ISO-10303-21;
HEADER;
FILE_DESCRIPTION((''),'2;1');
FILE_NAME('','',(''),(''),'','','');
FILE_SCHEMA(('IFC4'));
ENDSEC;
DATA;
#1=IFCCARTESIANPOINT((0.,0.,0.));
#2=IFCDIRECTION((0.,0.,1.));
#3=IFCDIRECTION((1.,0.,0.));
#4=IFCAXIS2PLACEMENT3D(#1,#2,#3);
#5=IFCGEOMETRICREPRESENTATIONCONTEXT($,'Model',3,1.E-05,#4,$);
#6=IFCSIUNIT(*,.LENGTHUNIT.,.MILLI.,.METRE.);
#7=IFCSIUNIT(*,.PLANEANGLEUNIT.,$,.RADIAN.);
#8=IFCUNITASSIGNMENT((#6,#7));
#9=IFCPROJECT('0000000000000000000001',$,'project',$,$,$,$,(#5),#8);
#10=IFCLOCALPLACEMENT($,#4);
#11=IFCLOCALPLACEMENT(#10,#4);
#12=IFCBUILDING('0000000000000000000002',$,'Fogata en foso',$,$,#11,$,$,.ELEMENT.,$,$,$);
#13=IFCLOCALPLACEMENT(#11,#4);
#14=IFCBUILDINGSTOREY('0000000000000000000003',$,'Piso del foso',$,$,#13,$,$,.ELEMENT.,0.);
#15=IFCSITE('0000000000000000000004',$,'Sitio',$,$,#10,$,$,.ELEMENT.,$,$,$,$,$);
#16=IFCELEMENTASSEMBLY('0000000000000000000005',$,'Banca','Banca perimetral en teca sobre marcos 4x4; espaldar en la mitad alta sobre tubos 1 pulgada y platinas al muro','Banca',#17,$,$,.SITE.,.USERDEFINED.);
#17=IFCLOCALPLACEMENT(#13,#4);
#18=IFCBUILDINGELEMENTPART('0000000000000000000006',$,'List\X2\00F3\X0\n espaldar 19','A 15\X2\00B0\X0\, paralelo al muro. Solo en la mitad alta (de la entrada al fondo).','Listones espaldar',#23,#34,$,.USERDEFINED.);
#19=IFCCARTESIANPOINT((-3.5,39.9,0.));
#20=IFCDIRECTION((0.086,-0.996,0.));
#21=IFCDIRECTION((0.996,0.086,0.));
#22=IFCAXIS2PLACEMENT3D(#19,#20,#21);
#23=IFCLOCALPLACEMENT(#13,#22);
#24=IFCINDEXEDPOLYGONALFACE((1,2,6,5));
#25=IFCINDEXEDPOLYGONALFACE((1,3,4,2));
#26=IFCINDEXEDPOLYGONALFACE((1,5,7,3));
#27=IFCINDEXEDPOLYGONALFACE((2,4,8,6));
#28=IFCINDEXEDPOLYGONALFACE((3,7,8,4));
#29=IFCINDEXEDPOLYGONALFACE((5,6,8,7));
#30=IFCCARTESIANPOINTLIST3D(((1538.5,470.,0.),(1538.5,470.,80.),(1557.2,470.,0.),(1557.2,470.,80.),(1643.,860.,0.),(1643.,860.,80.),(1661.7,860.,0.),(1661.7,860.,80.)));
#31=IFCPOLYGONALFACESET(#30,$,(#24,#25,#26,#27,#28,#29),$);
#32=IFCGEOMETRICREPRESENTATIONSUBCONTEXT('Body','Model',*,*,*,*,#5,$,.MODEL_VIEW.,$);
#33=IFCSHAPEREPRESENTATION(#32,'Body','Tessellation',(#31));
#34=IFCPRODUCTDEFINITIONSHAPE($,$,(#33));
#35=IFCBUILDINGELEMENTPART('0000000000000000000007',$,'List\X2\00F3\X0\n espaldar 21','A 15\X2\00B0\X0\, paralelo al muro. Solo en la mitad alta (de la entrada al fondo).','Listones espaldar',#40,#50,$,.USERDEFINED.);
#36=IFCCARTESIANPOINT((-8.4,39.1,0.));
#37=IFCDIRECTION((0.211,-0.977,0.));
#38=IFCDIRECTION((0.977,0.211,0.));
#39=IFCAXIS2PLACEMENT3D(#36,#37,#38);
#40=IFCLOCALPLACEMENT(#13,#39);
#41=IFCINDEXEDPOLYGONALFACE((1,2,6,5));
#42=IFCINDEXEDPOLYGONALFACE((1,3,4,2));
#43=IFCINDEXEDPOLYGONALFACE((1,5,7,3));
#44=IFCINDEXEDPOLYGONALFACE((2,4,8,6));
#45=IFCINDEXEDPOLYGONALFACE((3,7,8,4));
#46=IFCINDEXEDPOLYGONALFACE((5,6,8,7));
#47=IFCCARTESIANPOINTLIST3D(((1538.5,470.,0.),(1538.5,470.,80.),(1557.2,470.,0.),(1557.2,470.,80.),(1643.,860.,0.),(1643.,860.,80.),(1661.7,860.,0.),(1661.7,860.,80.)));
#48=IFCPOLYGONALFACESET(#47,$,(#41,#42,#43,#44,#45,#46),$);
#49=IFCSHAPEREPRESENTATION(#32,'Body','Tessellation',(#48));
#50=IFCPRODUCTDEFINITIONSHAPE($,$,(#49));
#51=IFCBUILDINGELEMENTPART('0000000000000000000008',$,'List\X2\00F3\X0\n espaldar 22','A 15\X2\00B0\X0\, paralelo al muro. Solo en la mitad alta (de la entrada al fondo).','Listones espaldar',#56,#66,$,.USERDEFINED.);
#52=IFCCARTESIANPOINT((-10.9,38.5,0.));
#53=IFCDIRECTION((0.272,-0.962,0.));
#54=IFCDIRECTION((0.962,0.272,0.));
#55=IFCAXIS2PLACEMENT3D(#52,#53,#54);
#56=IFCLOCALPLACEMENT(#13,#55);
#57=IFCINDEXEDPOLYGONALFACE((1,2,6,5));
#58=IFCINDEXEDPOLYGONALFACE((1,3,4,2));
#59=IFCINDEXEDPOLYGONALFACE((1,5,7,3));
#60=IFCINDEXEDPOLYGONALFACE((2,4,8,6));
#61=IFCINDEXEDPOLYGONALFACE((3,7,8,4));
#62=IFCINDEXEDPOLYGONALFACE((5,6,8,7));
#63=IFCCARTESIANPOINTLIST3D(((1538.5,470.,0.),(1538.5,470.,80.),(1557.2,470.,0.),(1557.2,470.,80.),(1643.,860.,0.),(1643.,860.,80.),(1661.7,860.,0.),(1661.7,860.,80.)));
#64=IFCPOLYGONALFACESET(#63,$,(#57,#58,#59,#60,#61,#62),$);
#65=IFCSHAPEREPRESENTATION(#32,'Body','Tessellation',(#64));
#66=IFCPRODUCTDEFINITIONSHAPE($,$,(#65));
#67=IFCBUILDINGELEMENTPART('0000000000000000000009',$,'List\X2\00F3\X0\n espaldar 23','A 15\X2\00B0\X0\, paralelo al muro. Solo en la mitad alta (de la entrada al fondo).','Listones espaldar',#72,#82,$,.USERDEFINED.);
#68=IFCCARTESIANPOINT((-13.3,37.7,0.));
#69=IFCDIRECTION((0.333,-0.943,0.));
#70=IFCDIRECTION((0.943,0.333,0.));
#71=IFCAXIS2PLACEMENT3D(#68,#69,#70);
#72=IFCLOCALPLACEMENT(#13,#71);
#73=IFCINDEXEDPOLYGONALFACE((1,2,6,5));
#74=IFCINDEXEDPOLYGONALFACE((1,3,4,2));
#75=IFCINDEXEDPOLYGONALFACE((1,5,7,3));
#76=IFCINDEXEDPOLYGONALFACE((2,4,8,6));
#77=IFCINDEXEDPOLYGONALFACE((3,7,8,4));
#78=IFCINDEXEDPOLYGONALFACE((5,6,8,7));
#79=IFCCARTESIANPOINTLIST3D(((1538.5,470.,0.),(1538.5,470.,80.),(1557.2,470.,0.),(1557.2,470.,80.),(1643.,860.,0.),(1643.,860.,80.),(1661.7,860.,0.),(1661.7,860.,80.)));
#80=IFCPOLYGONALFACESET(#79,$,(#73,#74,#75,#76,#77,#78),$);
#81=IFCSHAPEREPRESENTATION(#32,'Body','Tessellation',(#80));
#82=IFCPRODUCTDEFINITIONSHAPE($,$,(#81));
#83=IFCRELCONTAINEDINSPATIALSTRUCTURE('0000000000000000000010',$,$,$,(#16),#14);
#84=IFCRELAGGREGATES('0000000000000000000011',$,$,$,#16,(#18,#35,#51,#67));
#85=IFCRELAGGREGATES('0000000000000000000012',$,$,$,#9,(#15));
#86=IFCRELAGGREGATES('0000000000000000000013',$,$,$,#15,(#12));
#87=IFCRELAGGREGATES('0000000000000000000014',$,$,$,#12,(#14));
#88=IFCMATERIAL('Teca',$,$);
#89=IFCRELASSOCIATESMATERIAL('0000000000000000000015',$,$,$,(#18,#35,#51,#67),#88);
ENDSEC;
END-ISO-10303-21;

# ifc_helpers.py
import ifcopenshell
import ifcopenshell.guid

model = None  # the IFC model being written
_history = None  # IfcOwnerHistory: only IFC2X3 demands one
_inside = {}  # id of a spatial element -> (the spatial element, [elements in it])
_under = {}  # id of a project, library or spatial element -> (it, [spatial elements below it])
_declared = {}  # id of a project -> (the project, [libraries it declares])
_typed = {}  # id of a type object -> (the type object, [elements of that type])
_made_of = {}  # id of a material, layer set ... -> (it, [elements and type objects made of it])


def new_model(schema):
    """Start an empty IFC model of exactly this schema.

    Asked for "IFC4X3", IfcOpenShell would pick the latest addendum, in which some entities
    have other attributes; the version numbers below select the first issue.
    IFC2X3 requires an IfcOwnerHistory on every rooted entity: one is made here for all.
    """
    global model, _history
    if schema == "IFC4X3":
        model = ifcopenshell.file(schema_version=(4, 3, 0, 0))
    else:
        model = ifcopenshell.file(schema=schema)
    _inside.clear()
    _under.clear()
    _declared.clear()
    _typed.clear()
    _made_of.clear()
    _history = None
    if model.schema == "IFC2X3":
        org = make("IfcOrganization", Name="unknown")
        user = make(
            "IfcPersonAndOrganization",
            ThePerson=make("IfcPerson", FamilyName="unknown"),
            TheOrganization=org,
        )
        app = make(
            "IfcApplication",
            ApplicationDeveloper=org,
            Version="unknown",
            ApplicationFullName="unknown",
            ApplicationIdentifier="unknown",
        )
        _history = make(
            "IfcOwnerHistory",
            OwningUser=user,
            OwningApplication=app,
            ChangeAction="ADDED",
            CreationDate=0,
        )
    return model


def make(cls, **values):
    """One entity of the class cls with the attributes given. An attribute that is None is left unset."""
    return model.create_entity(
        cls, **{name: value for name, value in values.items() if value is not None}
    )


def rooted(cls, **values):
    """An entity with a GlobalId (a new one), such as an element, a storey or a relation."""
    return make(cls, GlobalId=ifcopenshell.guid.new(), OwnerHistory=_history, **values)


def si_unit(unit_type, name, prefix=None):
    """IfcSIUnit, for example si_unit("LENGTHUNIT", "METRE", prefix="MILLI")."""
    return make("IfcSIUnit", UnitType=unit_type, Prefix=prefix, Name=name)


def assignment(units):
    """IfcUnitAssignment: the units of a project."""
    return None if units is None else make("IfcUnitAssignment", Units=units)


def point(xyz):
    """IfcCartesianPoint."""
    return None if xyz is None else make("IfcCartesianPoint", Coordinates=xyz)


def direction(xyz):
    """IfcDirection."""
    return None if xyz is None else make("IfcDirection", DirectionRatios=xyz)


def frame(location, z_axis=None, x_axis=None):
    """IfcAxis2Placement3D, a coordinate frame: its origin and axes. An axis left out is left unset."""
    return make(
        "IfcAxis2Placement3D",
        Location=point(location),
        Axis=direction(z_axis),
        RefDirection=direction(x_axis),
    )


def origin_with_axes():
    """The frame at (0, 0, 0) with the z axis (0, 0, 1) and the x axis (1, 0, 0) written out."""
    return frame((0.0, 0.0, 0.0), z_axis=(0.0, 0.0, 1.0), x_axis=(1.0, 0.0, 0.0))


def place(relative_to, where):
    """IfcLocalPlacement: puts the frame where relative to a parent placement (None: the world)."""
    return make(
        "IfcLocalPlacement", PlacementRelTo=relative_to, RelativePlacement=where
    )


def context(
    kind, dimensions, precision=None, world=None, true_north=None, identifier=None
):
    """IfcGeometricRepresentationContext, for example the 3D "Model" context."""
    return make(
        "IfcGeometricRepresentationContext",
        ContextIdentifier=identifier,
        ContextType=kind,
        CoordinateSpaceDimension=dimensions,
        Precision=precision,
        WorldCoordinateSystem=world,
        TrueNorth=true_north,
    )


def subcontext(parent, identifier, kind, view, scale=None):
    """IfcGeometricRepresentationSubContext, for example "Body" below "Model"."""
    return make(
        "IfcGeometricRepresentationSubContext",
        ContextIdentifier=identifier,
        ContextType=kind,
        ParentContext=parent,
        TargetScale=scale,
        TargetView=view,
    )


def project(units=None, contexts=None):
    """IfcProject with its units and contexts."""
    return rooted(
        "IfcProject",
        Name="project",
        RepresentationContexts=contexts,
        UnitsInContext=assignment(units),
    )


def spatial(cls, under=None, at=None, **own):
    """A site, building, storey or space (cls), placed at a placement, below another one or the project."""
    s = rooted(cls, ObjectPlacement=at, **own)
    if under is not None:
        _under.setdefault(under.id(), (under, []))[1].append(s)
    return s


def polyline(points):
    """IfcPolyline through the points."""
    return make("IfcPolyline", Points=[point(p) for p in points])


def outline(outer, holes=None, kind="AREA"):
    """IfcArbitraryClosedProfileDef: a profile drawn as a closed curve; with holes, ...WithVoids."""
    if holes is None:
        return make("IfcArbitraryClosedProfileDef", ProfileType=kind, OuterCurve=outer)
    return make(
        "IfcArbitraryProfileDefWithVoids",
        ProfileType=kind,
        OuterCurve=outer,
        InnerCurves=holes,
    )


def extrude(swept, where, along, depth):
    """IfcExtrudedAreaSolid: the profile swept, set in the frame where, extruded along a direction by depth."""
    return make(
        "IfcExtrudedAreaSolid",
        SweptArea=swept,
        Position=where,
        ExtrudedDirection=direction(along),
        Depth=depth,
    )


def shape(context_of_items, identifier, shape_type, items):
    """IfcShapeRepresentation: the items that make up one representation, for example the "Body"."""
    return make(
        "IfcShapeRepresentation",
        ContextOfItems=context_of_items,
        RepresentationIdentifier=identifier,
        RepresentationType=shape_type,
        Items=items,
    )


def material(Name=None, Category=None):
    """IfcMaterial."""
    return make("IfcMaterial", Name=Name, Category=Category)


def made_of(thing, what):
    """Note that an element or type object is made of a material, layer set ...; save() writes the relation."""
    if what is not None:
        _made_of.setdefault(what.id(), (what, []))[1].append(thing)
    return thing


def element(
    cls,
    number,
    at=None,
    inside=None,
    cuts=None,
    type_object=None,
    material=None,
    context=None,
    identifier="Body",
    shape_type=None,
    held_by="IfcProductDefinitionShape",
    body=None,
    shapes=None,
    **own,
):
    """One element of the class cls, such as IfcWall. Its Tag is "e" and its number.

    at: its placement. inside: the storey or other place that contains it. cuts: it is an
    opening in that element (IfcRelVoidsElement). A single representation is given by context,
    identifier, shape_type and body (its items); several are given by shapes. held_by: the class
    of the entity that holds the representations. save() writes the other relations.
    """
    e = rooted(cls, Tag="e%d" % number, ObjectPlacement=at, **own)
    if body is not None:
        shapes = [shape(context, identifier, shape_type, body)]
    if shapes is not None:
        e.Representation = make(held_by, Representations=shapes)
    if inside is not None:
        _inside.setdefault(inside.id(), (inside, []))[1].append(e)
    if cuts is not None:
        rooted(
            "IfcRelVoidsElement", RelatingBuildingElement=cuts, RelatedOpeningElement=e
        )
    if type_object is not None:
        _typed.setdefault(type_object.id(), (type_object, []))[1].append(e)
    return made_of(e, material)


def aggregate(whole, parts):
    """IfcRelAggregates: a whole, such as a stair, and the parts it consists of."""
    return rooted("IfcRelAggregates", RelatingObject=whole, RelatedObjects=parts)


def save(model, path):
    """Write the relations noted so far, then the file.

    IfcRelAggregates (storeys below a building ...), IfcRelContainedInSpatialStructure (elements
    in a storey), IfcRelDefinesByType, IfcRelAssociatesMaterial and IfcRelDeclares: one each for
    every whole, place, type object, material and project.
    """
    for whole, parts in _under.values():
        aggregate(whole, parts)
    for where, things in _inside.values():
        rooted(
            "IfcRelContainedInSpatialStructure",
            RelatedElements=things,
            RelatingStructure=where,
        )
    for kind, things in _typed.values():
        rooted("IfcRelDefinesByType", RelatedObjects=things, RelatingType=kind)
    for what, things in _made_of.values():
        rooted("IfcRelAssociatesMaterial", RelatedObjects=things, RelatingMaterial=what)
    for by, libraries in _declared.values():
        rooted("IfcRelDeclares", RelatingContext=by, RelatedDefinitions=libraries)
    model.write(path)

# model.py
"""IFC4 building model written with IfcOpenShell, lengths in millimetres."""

from ifc_helpers import new_model, si_unit, frame, origin_with_axes, place, context, subcontext, project, spatial, polyline, outline, extrude, material, element, aggregate, save


model = new_model("IFC4")

# Units and contexts
model_context = context("Model", 3, precision=1e-05, world=origin_with_axes())
body_context = subcontext(model_context, "Body", "Model", "MODEL_VIEW")
ifc_project = project(units=[si_unit("LENGTHUNIT", "METRE", prefix="MILLI"), si_unit("PLANEANGLEUNIT", "RADIAN")], contexts=[model_context])

# Site, building, storey
site_placement = place(None, origin_with_axes())
site = spatial("IfcSite", under=ifc_project, at=site_placement, Name="Sitio", CompositionType="ELEMENT")
building_placement = place(site_placement, origin_with_axes())
building = spatial("IfcBuilding", under=site, at=building_placement, Name="Fogata en foso", CompositionType="ELEMENT")
storey_placement = place(building_placement, origin_with_axes())
storey = spatial("IfcBuildingStorey", under=building, at=storey_placement, Name="Piso del foso", CompositionType="ELEMENT", Elevation=0.0)

# Element assembly, building element parts
assembly_1_placement = place(storey_placement, origin_with_axes())
assembly_1 = element("IfcElementAssembly", 1, at=assembly_1_placement, inside=storey, Name="Banca", Description="Banca perimetral en teca sobre marcos 4x4; espaldar en la mitad alta sobre tubos 1 pulgada y platinas al muro", ObjectType="Banca", AssemblyPlace="SITE", PredefinedType="USERDEFINED")
ifc_material_1 = material(Name="Teca")
building_element_part_1_placement = place(storey_placement, frame((-3.5, 39.9, 0.0), z_axis=(0.086, -0.996, 0.0), x_axis=(0.996, 0.086, 0.0)))
building_element_part_1 = element("IfcBuildingElementPart", 2, at=building_element_part_1_placement, material=ifc_material_1, Name="Listón espaldar 19", Description="A 15°, paralelo al muro. Solo en la mitad alta (de la entrada al fondo).", ObjectType="Listones espaldar", PredefinedType="USERDEFINED", context=body_context, shape_type="SweptSolid", body=[
    extrude(outline(polyline([(1538.5, 470.0), (1557.2, 470.0), (1661.7, 860.0), (1643.0, 860.0), (1538.5, 470.0)])), origin_with_axes(), (0.0, 0.0, 1.0), 80.0),
])
building_element_part_2_placement = place(storey_placement, frame((-8.4, 39.1, 0.0), z_axis=(0.211, -0.977, 0.0), x_axis=(0.977, 0.211, 0.0)))
building_element_part_2 = element("IfcBuildingElementPart", 3, at=building_element_part_2_placement, material=ifc_material_1, Name="Listón espaldar 21", Description="A 15°, paralelo al muro. Solo en la mitad alta (de la entrada al fondo).", ObjectType="Listones espaldar", PredefinedType="USERDEFINED", context=body_context, shape_type="SweptSolid", body=[
    extrude(outline(polyline([(1538.5, 470.0), (1557.2, 470.0), (1661.7, 860.0), (1643.0, 860.0), (1538.5, 470.0)])), origin_with_axes(), (0.0, 0.0, 1.0), 80.0),
])
building_element_part_3_placement = place(storey_placement, frame((-10.9, 38.5, 0.0), z_axis=(0.272, -0.962, 0.0), x_axis=(0.962, 0.272, 0.0)))
building_element_part_3 = element("IfcBuildingElementPart", 4, at=building_element_part_3_placement, material=ifc_material_1, Name="Listón espaldar 22", Description="A 15°, paralelo al muro. Solo en la mitad alta (de la entrada al fondo).", ObjectType="Listones espaldar", PredefinedType="USERDEFINED", context=body_context, shape_type="SweptSolid", body=[
    extrude(outline(polyline([(1538.5, 470.0), (1557.2, 470.0), (1661.7, 860.0), (1643.0, 860.0), (1538.5, 470.0)])), origin_with_axes(), (0.0, 0.0, 1.0), 80.0),
])
building_element_part_4_placement = place(storey_placement, frame((-13.3, 37.7, 0.0), z_axis=(0.333, -0.943, 0.0), x_axis=(0.943, 0.333, 0.0)))
building_element_part_4 = element("IfcBuildingElementPart", 5, at=building_element_part_4_placement, material=ifc_material_1, Name="Listón espaldar 23", Description="A 15°, paralelo al muro. Solo en la mitad alta (de la entrada al fondo).", ObjectType="Listones espaldar", PredefinedType="USERDEFINED", context=body_context, shape_type="SweptSolid", body=[
    extrude(outline(polyline([(1538.5, 470.0), (1557.2, 470.0), (1661.7, 860.0), (1643.0, 860.0), (1538.5, 470.0)])), origin_with_axes(), (0.0, 0.0, 1.0), 80.0),
])
aggregate(assembly_1, [building_element_part_1, building_element_part_2, building_element_part_3, building_element_part_4])

save(model, "model.ifc")
